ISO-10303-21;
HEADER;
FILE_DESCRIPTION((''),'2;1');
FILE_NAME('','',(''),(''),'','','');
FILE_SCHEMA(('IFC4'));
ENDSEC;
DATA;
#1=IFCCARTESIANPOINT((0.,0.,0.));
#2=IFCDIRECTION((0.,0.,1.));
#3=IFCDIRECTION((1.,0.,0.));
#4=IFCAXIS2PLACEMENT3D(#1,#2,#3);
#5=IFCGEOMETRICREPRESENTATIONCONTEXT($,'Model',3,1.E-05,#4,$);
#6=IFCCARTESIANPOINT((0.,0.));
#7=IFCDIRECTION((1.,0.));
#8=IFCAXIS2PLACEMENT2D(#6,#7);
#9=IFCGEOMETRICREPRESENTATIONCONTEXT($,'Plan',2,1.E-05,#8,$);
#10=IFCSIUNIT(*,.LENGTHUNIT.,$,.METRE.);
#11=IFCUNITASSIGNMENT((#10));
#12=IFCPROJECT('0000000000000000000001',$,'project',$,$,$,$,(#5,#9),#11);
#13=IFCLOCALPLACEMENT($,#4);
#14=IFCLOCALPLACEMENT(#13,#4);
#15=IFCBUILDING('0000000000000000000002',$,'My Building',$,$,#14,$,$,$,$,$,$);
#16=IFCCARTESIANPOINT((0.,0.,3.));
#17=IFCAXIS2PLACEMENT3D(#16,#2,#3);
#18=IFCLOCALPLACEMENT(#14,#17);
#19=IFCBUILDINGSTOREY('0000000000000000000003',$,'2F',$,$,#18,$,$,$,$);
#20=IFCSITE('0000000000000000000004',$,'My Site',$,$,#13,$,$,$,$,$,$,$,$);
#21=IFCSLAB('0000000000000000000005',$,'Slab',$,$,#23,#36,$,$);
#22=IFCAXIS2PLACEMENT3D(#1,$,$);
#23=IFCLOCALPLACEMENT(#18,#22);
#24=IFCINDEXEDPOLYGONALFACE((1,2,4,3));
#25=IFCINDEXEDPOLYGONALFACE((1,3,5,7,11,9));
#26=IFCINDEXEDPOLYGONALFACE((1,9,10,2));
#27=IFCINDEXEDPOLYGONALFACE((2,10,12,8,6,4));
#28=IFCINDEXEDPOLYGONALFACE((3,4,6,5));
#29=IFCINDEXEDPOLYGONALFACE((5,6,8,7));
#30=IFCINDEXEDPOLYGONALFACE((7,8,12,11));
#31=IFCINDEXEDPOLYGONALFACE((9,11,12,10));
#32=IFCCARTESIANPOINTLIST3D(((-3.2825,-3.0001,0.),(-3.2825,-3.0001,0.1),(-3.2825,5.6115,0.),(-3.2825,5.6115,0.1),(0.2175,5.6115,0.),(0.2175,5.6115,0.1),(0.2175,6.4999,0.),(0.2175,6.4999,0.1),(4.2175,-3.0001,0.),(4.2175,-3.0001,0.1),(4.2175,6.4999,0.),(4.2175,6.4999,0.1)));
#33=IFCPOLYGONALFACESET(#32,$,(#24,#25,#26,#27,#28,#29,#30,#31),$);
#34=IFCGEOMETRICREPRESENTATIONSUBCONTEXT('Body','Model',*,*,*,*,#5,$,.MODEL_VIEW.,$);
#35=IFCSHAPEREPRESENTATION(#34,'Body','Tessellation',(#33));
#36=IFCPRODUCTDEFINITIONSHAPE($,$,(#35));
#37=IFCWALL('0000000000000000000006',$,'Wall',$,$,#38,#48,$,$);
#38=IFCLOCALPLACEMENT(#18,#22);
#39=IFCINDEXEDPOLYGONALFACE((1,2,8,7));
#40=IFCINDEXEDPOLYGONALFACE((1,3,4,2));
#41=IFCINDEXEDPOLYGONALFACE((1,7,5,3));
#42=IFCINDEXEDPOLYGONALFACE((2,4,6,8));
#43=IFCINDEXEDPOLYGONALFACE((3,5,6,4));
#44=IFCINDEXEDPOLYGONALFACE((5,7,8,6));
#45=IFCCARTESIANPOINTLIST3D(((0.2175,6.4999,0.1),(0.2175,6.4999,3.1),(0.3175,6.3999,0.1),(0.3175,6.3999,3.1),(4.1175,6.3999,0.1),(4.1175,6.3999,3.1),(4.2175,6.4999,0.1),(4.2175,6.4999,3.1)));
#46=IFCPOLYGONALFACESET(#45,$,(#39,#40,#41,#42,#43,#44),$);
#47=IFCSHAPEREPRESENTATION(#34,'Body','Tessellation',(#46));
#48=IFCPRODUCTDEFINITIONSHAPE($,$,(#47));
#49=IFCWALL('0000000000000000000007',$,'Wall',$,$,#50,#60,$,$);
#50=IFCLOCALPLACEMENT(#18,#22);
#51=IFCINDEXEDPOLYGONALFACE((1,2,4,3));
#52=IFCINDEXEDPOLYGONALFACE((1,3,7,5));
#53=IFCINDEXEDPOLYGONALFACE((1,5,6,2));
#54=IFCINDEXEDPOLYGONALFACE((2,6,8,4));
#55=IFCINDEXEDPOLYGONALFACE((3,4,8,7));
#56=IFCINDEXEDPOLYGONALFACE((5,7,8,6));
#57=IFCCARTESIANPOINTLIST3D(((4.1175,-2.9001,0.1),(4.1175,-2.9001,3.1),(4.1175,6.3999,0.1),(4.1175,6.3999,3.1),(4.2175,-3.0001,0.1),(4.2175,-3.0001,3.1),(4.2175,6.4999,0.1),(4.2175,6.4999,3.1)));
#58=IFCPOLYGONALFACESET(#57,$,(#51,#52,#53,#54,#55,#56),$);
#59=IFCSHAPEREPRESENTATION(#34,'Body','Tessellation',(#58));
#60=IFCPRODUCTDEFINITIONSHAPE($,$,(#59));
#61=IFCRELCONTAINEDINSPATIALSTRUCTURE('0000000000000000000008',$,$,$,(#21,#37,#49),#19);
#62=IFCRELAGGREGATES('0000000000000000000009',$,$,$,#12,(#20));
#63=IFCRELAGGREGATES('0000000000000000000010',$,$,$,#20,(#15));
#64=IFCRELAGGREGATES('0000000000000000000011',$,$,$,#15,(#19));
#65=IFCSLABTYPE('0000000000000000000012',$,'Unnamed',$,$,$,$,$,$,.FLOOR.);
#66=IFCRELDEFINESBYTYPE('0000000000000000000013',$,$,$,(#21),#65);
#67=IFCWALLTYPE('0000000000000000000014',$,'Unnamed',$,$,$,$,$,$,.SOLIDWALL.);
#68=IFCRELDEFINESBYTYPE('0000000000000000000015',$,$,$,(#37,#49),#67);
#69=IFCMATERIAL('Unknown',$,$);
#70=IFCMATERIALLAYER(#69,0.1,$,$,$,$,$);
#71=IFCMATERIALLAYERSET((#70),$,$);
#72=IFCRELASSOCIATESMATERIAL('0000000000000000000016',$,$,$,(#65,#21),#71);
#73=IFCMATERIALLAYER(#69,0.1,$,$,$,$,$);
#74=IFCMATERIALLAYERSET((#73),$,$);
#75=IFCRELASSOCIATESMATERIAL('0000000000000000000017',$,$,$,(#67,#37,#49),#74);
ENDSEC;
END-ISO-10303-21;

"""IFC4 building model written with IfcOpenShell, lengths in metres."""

from ifc_helpers import new_model, si_unit, frame, origin_with_axes, origin_2d_with_axis, place, context, subcontext, project, spatial, line, indexed_curve, outline, extrude, material, layer, layer_set, layer_usage, type_object, element, save


model = new_model("IFC4")

# Units and contexts
model_context = context("Model", 3, precision=1e-05, world=origin_with_axes())
plan_context = context("Plan", 2, precision=1e-05, world=origin_2d_with_axis())
body_context_1 = subcontext(model_context, "Body", "Model", "MODEL_VIEW")
ifc_project = project(units=[si_unit("LENGTHUNIT", "METRE")], contexts=[model_context, plan_context])

# Site, building, storey
site_placement = place(None, origin_with_axes())
site = spatial("IfcSite", under=ifc_project, at=site_placement, Name="My Site")
building_placement = place(site_placement, origin_with_axes())
building = spatial("IfcBuilding", under=site, at=building_placement, Name="My Building")
storey_placement = place(building_placement, frame((0.0, 0.0, 3.0), z_axis=(0.0, 0.0, 1.0), x_axis=(1.0, 0.0, 0.0)))
storey = spatial("IfcBuildingStorey", under=building, at=storey_placement, Name="2F")

# Slab
ifc_material = material(Name="Unknown")
ifc_layer_1 = layer(ifc_material, 0.1)
ifc_layer_set_1 = layer_set([ifc_layer_1])
ifc_layer_usage_1 = layer_usage(ifc_layer_set_1, "AXIS3", "POSITIVE", -0.1)
slab_type = type_object("IfcSlabType", Name="Unnamed", PredefinedType="FLOOR", material=ifc_layer_set_1)
slab_placement = place(storey_placement, frame((0.2175, 6.4999, 0.1), z_axis=(0.0, 0.0, 1.0), x_axis=(1.0, 0.0, 0.0)))
element("IfcSlab", 1, at=slab_placement, inside=storey, type_object=slab_type, material=ifc_layer_usage_1, Name="Slab", context=body_context_1, shape_type="SweptSolid", body=[
    extrude(outline(indexed_curve([(0.0, 0.0), (4.0, 0.0), (4.0, -9.5), (-3.5, -9.5), (-3.5, -0.8884), (0.0, -0.8884), (0.0, 0.0)])), frame((0.0, 0.0, -0.1), z_axis=(0.0, 0.0, 1.0), x_axis=(1.0, 0.0, 0.0)), (0.0, 0.0, 1.0), 0.1),
])

# Walls
ifc_layer_2 = layer(ifc_material, 0.1)
ifc_layer_set_2 = layer_set([ifc_layer_2])
ifc_layer_usage_2 = layer_usage(ifc_layer_set_2, "AXIS2", "POSITIVE", 0.0)
wall_type = type_object("IfcWallType", Name="Unnamed", PredefinedType="SOLIDWALL", material=ifc_layer_set_2)
wall_1_placement = place(storey_placement, frame((0.3175, 6.3999, 0.1), z_axis=(0.0, 0.0, 1.0), x_axis=(1.0, 0.0, 0.0)))
element("IfcWall", 2, at=wall_1_placement, inside=storey, type_object=wall_type, material=ifc_layer_usage_2, Name="Wall", context=body_context_1, shape_type="SweptSolid", body=[
    extrude(outline(indexed_curve([(0.0, 0.0), (-0.1, 0.1), (3.9, 0.1), (3.8, 0.0)], segments=[line(1, 2, 3, 4, 1)])), origin_with_axes(), (0.0, 0.0, 1.0), 3.0),
])
ifc_layer_usage_3 = layer_usage(ifc_layer_set_2, "AXIS2", "POSITIVE", 0.0)
wall_2_placement = place(storey_placement, frame((4.1175, 6.3999, 0.1), z_axis=(0.0, 0.0, 1.0), x_axis=(0.0, -1.0, 0.0)))
element("IfcWall", 3, at=wall_2_placement, inside=storey, type_object=wall_type, material=ifc_layer_usage_3, Name="Wall", context=body_context_1, shape_type="SweptSolid", body=[
    extrude(outline(indexed_curve([(0.0, 0.0), (-0.1, 0.1), (9.4, 0.1), (9.3, 0.0)], segments=[line(1, 2, 3, 4, 1)])), origin_with_axes(), (0.0, 0.0, 1.0), 3.0),
])

save(model, "model.ifc")
